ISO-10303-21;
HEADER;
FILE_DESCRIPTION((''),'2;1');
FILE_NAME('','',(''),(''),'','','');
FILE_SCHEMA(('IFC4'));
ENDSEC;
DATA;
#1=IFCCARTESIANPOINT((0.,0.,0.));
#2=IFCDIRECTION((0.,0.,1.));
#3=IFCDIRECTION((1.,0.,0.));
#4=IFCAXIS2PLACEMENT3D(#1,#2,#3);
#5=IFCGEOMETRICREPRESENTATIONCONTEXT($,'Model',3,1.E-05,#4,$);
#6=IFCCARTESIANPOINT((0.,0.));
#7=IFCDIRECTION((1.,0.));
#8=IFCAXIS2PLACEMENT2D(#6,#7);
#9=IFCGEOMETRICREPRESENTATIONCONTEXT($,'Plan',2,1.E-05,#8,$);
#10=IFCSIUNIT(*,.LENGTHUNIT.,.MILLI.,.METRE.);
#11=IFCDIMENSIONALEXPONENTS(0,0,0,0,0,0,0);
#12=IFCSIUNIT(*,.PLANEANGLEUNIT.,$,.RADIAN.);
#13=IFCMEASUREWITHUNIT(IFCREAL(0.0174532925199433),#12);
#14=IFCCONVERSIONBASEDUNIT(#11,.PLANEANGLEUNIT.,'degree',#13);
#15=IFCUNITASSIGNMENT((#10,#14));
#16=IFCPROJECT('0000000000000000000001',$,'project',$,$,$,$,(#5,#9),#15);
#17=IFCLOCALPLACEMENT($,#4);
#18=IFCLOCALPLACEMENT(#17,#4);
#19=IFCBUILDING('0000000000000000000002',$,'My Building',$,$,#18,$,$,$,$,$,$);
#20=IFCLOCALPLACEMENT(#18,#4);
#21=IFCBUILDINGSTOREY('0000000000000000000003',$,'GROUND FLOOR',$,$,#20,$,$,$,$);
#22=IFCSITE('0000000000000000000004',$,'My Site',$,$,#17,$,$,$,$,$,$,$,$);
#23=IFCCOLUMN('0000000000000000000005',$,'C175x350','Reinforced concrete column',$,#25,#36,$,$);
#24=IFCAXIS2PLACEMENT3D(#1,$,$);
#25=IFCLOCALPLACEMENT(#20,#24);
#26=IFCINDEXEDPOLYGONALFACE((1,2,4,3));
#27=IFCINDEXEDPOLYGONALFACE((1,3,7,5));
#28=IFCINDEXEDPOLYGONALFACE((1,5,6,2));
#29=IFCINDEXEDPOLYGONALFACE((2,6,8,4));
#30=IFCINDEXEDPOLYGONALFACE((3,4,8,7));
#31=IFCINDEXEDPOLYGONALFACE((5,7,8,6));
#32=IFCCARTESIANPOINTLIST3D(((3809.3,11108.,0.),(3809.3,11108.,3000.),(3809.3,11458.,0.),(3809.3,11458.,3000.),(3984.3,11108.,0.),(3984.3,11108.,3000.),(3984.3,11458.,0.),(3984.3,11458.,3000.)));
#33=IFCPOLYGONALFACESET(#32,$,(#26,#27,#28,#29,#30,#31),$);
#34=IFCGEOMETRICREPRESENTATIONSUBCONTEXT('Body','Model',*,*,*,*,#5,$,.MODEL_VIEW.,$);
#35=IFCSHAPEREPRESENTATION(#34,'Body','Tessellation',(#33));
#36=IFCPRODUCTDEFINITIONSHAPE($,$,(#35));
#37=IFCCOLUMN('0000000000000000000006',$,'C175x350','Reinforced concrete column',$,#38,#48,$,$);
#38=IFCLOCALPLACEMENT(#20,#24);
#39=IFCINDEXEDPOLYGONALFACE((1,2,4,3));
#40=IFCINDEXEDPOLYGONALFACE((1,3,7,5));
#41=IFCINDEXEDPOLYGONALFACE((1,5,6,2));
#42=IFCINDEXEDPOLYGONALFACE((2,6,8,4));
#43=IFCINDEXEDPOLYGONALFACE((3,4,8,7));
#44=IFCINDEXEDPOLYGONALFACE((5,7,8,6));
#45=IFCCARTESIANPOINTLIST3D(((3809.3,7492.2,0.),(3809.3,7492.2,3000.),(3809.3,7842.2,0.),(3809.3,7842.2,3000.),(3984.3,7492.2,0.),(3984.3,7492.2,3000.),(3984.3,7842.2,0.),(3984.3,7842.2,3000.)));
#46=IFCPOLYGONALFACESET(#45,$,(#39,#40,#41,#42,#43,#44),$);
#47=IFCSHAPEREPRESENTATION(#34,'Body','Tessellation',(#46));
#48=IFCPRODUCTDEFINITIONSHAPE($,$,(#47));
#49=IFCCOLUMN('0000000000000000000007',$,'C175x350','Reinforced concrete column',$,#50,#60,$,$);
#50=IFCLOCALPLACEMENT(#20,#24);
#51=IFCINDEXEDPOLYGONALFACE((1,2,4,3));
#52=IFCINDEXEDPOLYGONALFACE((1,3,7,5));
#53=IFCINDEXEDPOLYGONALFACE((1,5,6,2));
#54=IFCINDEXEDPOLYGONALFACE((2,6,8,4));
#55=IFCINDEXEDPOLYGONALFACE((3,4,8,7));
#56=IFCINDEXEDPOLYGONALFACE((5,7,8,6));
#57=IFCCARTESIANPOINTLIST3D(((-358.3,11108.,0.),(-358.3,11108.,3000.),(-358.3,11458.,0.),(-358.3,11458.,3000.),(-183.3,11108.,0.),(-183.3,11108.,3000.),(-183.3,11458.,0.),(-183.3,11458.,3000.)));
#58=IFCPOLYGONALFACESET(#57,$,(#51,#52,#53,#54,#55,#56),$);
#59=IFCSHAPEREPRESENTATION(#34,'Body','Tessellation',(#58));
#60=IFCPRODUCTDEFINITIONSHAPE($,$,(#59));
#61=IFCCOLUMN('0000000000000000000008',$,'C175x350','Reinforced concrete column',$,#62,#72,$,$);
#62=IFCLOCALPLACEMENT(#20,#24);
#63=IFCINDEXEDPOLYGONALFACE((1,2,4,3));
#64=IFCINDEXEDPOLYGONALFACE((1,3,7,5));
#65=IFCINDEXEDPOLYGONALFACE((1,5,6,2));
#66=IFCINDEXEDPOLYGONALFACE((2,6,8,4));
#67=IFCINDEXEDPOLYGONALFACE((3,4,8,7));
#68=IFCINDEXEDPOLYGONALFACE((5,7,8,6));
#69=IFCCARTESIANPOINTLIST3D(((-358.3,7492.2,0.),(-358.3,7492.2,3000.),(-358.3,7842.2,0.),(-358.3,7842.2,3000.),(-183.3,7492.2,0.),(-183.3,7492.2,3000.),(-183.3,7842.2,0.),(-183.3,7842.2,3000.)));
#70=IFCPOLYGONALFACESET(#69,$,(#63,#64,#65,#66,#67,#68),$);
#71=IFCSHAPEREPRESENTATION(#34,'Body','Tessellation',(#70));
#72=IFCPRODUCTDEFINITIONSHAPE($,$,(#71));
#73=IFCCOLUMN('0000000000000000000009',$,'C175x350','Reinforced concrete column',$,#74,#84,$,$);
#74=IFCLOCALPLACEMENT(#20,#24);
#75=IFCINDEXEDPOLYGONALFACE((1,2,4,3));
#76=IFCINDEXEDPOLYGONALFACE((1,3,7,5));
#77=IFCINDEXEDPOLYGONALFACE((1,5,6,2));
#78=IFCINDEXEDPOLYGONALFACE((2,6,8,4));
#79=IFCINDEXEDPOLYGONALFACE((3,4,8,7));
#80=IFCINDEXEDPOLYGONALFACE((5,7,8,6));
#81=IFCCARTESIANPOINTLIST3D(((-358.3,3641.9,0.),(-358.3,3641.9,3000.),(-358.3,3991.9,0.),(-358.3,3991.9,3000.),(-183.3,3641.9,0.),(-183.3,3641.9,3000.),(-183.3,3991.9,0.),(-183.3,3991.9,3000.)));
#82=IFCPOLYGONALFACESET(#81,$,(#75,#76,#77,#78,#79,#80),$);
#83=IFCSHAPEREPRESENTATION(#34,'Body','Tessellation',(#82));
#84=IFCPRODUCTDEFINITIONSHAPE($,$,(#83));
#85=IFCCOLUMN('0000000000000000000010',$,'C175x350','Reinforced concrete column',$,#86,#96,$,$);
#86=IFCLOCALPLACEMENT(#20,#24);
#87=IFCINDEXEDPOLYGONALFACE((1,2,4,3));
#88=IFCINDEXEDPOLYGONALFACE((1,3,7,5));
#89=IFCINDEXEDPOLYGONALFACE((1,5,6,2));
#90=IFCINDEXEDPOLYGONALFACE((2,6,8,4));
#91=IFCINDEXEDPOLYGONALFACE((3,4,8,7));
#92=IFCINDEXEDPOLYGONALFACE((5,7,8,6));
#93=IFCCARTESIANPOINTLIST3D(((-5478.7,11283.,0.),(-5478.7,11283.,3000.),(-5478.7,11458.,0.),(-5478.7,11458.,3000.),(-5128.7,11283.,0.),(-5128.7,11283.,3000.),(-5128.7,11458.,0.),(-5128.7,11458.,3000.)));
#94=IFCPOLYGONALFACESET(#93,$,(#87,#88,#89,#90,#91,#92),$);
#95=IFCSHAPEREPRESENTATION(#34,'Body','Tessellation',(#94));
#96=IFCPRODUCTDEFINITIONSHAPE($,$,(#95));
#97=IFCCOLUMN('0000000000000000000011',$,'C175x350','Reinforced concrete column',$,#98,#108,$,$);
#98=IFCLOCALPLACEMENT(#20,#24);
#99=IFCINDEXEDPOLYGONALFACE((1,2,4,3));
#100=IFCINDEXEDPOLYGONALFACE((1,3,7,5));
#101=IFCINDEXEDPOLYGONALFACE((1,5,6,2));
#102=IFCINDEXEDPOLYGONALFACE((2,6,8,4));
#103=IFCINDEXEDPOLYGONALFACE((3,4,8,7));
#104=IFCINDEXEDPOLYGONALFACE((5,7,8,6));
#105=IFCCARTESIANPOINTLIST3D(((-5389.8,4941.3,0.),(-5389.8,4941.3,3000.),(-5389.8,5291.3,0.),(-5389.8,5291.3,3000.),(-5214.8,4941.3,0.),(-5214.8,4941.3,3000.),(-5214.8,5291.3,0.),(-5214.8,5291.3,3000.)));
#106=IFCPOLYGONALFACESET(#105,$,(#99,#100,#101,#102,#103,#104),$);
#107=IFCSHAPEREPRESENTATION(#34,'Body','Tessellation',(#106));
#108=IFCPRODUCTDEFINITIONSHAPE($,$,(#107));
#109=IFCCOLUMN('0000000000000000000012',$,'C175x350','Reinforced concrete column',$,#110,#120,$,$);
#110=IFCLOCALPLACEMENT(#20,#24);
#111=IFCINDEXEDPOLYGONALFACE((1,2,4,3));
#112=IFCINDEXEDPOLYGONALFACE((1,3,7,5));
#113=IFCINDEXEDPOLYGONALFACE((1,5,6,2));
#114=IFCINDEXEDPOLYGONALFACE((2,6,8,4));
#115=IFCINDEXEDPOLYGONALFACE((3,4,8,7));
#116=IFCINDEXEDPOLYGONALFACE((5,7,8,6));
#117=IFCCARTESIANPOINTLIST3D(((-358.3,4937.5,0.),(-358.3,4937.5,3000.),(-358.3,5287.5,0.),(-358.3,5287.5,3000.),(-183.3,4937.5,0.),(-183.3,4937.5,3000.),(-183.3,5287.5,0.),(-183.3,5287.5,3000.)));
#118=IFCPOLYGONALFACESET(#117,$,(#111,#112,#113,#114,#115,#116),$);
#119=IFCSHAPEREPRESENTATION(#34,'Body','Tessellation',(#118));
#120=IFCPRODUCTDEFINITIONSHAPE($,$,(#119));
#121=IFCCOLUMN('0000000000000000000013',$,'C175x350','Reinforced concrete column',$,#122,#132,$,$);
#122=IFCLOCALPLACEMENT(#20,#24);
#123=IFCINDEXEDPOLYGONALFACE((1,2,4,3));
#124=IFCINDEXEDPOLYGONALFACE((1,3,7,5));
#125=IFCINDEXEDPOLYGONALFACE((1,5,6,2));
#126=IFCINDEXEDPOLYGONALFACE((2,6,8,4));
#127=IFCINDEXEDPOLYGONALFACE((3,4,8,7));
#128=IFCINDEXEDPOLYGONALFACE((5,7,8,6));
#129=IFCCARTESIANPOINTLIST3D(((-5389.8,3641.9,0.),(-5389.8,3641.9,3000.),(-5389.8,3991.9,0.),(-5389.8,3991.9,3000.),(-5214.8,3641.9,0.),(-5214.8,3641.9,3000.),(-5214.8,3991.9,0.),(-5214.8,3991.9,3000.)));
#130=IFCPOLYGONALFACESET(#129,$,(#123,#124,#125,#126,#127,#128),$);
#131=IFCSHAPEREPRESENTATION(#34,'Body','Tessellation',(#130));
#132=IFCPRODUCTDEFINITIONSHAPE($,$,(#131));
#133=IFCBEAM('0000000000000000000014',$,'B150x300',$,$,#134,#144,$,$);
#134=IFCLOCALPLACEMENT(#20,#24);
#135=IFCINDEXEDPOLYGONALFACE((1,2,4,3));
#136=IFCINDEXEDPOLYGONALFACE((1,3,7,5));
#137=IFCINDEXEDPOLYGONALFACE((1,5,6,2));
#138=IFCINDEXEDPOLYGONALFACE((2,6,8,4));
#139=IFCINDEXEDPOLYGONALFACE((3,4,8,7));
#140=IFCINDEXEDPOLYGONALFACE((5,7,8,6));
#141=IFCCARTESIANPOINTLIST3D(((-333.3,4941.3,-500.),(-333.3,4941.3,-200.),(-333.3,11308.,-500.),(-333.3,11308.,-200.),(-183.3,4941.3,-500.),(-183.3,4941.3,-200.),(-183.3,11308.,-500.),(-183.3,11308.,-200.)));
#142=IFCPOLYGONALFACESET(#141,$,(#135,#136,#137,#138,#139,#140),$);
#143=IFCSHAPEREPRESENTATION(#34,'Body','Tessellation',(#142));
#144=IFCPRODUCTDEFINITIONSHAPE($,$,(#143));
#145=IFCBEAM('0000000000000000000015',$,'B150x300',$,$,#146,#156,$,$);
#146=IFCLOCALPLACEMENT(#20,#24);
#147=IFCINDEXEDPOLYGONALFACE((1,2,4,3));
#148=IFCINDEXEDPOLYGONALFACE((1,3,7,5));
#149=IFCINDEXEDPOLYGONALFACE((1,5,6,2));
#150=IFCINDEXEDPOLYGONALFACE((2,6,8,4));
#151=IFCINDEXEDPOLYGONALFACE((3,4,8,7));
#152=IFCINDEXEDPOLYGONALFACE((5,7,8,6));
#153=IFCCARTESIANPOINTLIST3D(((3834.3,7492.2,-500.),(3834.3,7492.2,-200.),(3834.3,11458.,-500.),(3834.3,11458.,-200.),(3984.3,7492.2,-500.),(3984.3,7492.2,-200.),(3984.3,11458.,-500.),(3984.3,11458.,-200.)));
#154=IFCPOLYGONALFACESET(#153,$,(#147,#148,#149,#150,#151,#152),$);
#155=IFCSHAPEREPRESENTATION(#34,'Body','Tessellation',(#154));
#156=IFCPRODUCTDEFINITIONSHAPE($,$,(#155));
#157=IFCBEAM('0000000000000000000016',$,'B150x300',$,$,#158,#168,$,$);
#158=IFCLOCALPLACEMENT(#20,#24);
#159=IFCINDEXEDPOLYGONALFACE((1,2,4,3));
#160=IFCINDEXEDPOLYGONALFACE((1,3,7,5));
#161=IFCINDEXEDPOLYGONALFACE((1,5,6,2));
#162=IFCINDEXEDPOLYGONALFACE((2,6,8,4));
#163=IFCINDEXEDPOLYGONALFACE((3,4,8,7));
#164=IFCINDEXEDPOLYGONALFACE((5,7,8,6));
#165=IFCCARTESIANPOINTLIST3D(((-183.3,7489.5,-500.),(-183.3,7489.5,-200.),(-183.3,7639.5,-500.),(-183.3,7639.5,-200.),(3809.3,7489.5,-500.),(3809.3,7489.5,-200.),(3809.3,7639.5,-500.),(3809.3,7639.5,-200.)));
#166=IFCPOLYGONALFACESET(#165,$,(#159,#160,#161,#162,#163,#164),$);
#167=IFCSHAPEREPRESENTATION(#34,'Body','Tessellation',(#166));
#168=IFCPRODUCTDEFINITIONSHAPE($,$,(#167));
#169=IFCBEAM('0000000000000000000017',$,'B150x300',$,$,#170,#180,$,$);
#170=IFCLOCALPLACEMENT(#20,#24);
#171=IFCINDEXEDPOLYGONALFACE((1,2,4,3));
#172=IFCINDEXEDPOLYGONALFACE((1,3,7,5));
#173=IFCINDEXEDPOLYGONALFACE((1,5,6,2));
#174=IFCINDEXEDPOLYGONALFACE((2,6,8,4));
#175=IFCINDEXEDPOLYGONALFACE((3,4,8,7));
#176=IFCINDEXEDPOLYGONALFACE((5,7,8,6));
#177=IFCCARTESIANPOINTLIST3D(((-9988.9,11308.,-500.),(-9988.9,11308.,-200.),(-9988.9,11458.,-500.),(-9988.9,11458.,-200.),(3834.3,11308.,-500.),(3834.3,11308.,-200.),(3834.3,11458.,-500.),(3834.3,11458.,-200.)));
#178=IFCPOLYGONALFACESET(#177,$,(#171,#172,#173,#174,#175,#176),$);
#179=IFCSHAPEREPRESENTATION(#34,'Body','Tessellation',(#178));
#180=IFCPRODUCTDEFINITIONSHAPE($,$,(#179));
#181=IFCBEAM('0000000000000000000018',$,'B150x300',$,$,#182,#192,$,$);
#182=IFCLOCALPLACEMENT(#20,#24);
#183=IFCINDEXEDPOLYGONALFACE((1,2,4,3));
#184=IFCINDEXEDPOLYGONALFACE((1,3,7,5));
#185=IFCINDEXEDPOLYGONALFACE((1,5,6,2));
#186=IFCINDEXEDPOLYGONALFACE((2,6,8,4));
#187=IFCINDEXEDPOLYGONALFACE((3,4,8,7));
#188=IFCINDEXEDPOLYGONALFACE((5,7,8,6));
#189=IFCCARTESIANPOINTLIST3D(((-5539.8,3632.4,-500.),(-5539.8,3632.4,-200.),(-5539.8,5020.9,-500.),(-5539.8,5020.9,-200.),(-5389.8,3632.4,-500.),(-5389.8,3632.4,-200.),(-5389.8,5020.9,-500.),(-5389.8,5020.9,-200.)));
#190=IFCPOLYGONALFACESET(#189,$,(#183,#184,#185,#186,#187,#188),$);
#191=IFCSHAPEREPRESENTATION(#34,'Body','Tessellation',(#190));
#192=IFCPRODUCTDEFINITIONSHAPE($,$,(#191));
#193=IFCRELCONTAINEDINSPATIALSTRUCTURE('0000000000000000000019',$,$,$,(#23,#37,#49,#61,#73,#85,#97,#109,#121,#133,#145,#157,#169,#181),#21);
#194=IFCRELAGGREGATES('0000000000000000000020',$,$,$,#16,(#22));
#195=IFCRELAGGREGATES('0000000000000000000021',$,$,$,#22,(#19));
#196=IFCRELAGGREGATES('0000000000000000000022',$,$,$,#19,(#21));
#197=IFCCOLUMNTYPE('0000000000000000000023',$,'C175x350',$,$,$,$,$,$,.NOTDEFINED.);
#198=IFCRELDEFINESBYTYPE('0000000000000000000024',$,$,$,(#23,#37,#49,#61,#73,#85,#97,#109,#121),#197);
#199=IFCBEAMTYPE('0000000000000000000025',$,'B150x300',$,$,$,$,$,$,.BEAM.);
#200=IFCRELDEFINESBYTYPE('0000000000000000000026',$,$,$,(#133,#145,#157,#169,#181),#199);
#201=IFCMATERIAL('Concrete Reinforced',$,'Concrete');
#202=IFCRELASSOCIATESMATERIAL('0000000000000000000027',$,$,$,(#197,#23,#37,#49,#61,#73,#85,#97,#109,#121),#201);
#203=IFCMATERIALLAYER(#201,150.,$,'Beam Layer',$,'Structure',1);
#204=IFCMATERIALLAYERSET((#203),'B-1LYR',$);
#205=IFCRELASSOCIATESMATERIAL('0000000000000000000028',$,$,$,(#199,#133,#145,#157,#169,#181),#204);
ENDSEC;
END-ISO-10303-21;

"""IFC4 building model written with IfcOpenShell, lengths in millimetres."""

from ifc_helpers import new_model, entity, si_unit, converted_unit, frame, origin_with_axes, origin_2d_with_axis, place, context, subcontext, project, spatial, indexed_curve, rectangle, outline, extrude, material, layer, layer_set, layer_usage, material_profile, profile_set, profile_usage, type_object, element, save


model = new_model("IFC4")

# Units and contexts
model_context = context("Model", 3, precision=1e-05, world=origin_with_axes())
plan_context = context("Plan", 2, precision=1e-05, world=origin_2d_with_axis())
body_context_1 = subcontext(model_context, "Body", "Model", "MODEL_VIEW")
ifc_project = project(units=[si_unit("LENGTHUNIT", "METRE", prefix="MILLI"), converted_unit("PLANEANGLEUNIT", "degree", entity("IfcReal", 0.0174532925199433), si_unit("PLANEANGLEUNIT", "RADIAN"), dimensions=[0, 0, 0, 0, 0, 0, 0])], contexts=[model_context, plan_context])

# Site, building, storey
site_placement = place(None, origin_with_axes())
site = spatial("IfcSite", under=ifc_project, at=site_placement, Name="My Site")
building_placement = place(site_placement, origin_with_axes())
building = spatial("IfcBuilding", under=site, at=building_placement, Name="My Building")
storey_placement = place(building_placement, origin_with_axes())
storey = spatial("IfcBuildingStorey", under=building, at=storey_placement, Name="GROUND FLOOR")

# Columns
ifc_material_1 = material(Name="Concrete Reinforced", Category="Concrete")
ifc_material_profile = material_profile(ifc_material_1, rectangle(XDim=175.0, YDim=350.0), Name="R. C. Layer", Category="Structure", Priority=1)
ifc_profile_set = profile_set([ifc_material_profile], Name="COL_1LYR")
ifc_profile_usage_1 = profile_usage(ifc_profile_set, cardinal=5)
column_type = type_object("IfcColumnType", Name="C175x350", PredefinedType="NOTDEFINED", material=ifc_profile_set)
column_1_placement = place(storey_placement, frame((3896.8, 11283.0, 0.0), z_axis=(0.0, 0.0, 1.0), x_axis=(1.0, 0.0, 0.0)))
element("IfcColumn", 1, at=column_1_placement, inside=storey, type_object=column_type, material=ifc_profile_usage_1, Name="C175x350", Description="Reinforced concrete column", context=body_context_1, shape_type="SweptSolid", body=[
    extrude(rectangle(XDim=175.0, YDim=350.0), origin_with_axes(), (0.0, 0.0, 1.0), 3000.0),
])
ifc_profile_usage_2 = profile_usage(ifc_profile_set, cardinal=5)
column_2_placement = place(storey_placement, frame((3896.8, 7667.2, 0.0), z_axis=(0.0, 0.0, 1.0), x_axis=(1.0, 0.0, 0.0)))
element("IfcColumn", 2, at=column_2_placement, inside=storey, type_object=column_type, material=ifc_profile_usage_2, Name="C175x350", Description="Reinforced concrete column", context=body_context_1, shape_type="SweptSolid", body=[
    extrude(rectangle(XDim=175.0, YDim=350.0), origin_with_axes(), (0.0, 0.0, 1.0), 3000.0),
])
ifc_profile_usage_3 = profile_usage(ifc_profile_set, cardinal=5)
column_3_placement = place(storey_placement, frame((-270.8, 11283.0, 0.0), z_axis=(0.0, 0.0, 1.0), x_axis=(1.0, 0.0, 0.0)))
element("IfcColumn", 3, at=column_3_placement, inside=storey, type_object=column_type, material=ifc_profile_usage_3, Name="C175x350", Description="Reinforced concrete column", context=body_context_1, shape_type="SweptSolid", body=[
    extrude(rectangle(XDim=175.0, YDim=350.0), origin_with_axes(), (0.0, 0.0, 1.0), 3000.0),
])
ifc_profile_usage_4 = profile_usage(ifc_profile_set, cardinal=5)
column_4_placement = place(storey_placement, frame((-270.8, 7667.2, 0.0), z_axis=(0.0, 0.0, 1.0), x_axis=(1.0, 0.0, 0.0)))
element("IfcColumn", 4, at=column_4_placement, inside=storey, type_object=column_type, material=ifc_profile_usage_4, Name="C175x350", Description="Reinforced concrete column", context=body_context_1, shape_type="SweptSolid", body=[
    extrude(rectangle(XDim=175.0, YDim=350.0), origin_with_axes(), (0.0, 0.0, 1.0), 3000.0),
])
ifc_profile_usage_5 = profile_usage(ifc_profile_set, cardinal=5)
column_5_placement = place(storey_placement, frame((-270.8, 3816.9, 0.0), z_axis=(0.0, 0.0, 1.0), x_axis=(1.0, 0.0, 0.0)))
element("IfcColumn", 5, at=column_5_placement, inside=storey, type_object=column_type, material=ifc_profile_usage_5, Name="C175x350", Description="Reinforced concrete column", context=body_context_1, shape_type="SweptSolid", body=[
    extrude(rectangle(XDim=175.0, YDim=350.0), origin_with_axes(), (0.0, 0.0, 1.0), 3000.0),
])
ifc_profile_usage_6 = profile_usage(ifc_profile_set, cardinal=5)
column_6_placement = place(storey_placement, frame((-5303.7, 11370.5, 0.0), z_axis=(0.0, 0.0, 1.0), x_axis=(0.0, -1.0, 0.0)))
element("IfcColumn", 6, at=column_6_placement, inside=storey, type_object=column_type, material=ifc_profile_usage_6, Name="C175x350", Description="Reinforced concrete column", context=body_context_1, shape_type="SweptSolid", body=[
    extrude(rectangle(XDim=175.0, YDim=350.0), origin_with_axes(), (0.0, 0.0, 1.0), 3000.0),
])
ifc_profile_usage_7 = profile_usage(ifc_profile_set, cardinal=5)
column_7_placement = place(storey_placement, frame((-5302.3, 5116.3, 0.0), z_axis=(0.0, 0.0, 1.0), x_axis=(1.0, 0.0, 0.0)))
element("IfcColumn", 7, at=column_7_placement, inside=storey, type_object=column_type, material=ifc_profile_usage_7, Name="C175x350", Description="Reinforced concrete column", context=body_context_1, shape_type="SweptSolid", body=[
    extrude(rectangle(XDim=175.0, YDim=350.0), origin_with_axes(), (0.0, 0.0, 1.0), 3000.0),
])
ifc_profile_usage_8 = profile_usage(ifc_profile_set, cardinal=5)
column_8_placement = place(storey_placement, frame((-270.8, 5112.5, 0.0), z_axis=(0.0, 0.0, 1.0), x_axis=(1.0, 0.0, 0.0)))
element("IfcColumn", 8, at=column_8_placement, inside=storey, type_object=column_type, material=ifc_profile_usage_8, Name="C175x350", Description="Reinforced concrete column", context=body_context_1, shape_type="SweptSolid", body=[
    extrude(rectangle(XDim=175.0, YDim=350.0), origin_with_axes(), (0.0, 0.0, 1.0), 3000.0),
])
ifc_profile_usage_9 = profile_usage(ifc_profile_set, cardinal=5)
column_9_placement = place(storey_placement, frame((-5302.3, 3816.9, 0.0), z_axis=(0.0, 0.0, 1.0), x_axis=(1.0, 0.0, 0.0)))
element("IfcColumn", 9, at=column_9_placement, inside=storey, type_object=column_type, material=ifc_profile_usage_9, Name="C175x350", Description="Reinforced concrete column", context=body_context_1, shape_type="SweptSolid", body=[
    extrude(rectangle(XDim=175.0, YDim=350.0), origin_with_axes(), (0.0, 0.0, 1.0), 3000.0),
])

# Beams
ifc_layer_1 = layer(ifc_material_1, 150.0, Name="Beam Layer", Category="Structure", Priority=1)
ifc_layer_set_1 = layer_set([ifc_layer_1], Name="B-1LYR")
ifc_layer_usage_1 = layer_usage(ifc_layer_set_1, "AXIS2", "POSITIVE", 0.0)
beam_type = type_object("IfcBeamType", Name="B150x300", PredefinedType="BEAM", material=ifc_layer_set_1)
beam_1_placement = place(storey_placement, frame((-183.3, 4941.3, -500.0), z_axis=(0.0, 0.0, 1.0), x_axis=(0.0, 1.0, 0.0)))
element("IfcBeam", 10, at=beam_1_placement, inside=storey, type_object=beam_type, material=ifc_layer_usage_1, Name="B150x300", context=body_context_1, shape_type="SweptSolid", body=[
    extrude(outline(indexed_curve([(0.0, 0.0), (0.0, 150.0), (6366.6, 150.0), (6366.6, 0.0), (0.0, 0.0)], self_intersect=False)), origin_with_axes(), (0.0, 0.0, 1.0), 300.0),
])
ifc_layer_usage_2 = layer_usage(ifc_layer_set_1, "AXIS2", "POSITIVE", 0.0)
beam_2_placement = place(storey_placement, frame((3984.3, 7492.2, -500.0), z_axis=(0.0, 0.0, 1.0), x_axis=(0.0, 1.0, 0.0)))
element("IfcBeam", 11, at=beam_2_placement, inside=storey, type_object=beam_type, material=ifc_layer_usage_2, Name="B150x300", context=body_context_1, shape_type="SweptSolid", body=[
    extrude(outline(indexed_curve([(0.0, 0.0), (0.0, 150.0), (3965.8, 150.0), (3965.8, 0.0), (0.0, 0.0)], self_intersect=False)), origin_with_axes(), (0.0, 0.0, 1.0), 300.0),
])
ifc_layer_usage_3 = layer_usage(ifc_layer_set_1, "AXIS2", "POSITIVE", 0.0)
beam_3_placement = place(storey_placement, frame((-183.3, 7489.5, -500.0), z_axis=(0.0, 0.0, 1.0), x_axis=(1.0, 0.0, 0.0)))
element("IfcBeam", 12, at=beam_3_placement, inside=storey, type_object=beam_type, material=ifc_layer_usage_3, Name="B150x300", context=body_context_1, shape_type="SweptSolid", body=[
    extrude(outline(indexed_curve([(0.0, 0.0), (0.0, 150.0), (3992.6, 150.0), (3992.6, 0.0), (0.0, 0.0)], self_intersect=False)), origin_with_axes(), (0.0, 0.0, 1.0), 300.0),
])
ifc_layer_usage_4 = layer_usage(ifc_layer_set_1, "AXIS2", "POSITIVE", 0.0)
beam_4_placement = place(storey_placement, frame((3834.3, 11458.0, -500.0), z_axis=(0.0, 0.0, 1.0), x_axis=(-1.0, 0.0, 0.0)))
element("IfcBeam", 13, at=beam_4_placement, inside=storey, type_object=beam_type, material=ifc_layer_usage_4, Name="B150x300", context=body_context_1, shape_type="SweptSolid", body=[
    extrude(outline(indexed_curve([(0.0, 0.0), (0.0, 150.0), (13823.2, 150.0), (13823.2, 0.0), (0.0, 0.0)], self_intersect=False)), origin_with_axes(), (0.0, 0.0, 1.0), 300.0),
])
ifc_layer_usage_5 = layer_usage(ifc_layer_set_1, "AXIS2", "POSITIVE", 0.0)
beam_5_placement = place(storey_placement, frame((-5389.8, 3632.4, -500.0), z_axis=(0.0, 0.0, 1.0), x_axis=(0.0, 1.0, 0.0)))
element("IfcBeam", 14, at=beam_5_placement, inside=storey, type_object=beam_type, material=ifc_layer_usage_5, Name="B150x300", context=body_context_1, shape_type="SweptSolid", body=[
    extrude(outline(indexed_curve([(0.0, 0.0), (0.0, 150.0), (1388.5, 150.0), (1388.5, 0.0), (0.0, 0.0)], self_intersect=False)), origin_with_axes(), (0.0, 0.0, 1.0), 300.0),
])

save(model, "model.ifc")
